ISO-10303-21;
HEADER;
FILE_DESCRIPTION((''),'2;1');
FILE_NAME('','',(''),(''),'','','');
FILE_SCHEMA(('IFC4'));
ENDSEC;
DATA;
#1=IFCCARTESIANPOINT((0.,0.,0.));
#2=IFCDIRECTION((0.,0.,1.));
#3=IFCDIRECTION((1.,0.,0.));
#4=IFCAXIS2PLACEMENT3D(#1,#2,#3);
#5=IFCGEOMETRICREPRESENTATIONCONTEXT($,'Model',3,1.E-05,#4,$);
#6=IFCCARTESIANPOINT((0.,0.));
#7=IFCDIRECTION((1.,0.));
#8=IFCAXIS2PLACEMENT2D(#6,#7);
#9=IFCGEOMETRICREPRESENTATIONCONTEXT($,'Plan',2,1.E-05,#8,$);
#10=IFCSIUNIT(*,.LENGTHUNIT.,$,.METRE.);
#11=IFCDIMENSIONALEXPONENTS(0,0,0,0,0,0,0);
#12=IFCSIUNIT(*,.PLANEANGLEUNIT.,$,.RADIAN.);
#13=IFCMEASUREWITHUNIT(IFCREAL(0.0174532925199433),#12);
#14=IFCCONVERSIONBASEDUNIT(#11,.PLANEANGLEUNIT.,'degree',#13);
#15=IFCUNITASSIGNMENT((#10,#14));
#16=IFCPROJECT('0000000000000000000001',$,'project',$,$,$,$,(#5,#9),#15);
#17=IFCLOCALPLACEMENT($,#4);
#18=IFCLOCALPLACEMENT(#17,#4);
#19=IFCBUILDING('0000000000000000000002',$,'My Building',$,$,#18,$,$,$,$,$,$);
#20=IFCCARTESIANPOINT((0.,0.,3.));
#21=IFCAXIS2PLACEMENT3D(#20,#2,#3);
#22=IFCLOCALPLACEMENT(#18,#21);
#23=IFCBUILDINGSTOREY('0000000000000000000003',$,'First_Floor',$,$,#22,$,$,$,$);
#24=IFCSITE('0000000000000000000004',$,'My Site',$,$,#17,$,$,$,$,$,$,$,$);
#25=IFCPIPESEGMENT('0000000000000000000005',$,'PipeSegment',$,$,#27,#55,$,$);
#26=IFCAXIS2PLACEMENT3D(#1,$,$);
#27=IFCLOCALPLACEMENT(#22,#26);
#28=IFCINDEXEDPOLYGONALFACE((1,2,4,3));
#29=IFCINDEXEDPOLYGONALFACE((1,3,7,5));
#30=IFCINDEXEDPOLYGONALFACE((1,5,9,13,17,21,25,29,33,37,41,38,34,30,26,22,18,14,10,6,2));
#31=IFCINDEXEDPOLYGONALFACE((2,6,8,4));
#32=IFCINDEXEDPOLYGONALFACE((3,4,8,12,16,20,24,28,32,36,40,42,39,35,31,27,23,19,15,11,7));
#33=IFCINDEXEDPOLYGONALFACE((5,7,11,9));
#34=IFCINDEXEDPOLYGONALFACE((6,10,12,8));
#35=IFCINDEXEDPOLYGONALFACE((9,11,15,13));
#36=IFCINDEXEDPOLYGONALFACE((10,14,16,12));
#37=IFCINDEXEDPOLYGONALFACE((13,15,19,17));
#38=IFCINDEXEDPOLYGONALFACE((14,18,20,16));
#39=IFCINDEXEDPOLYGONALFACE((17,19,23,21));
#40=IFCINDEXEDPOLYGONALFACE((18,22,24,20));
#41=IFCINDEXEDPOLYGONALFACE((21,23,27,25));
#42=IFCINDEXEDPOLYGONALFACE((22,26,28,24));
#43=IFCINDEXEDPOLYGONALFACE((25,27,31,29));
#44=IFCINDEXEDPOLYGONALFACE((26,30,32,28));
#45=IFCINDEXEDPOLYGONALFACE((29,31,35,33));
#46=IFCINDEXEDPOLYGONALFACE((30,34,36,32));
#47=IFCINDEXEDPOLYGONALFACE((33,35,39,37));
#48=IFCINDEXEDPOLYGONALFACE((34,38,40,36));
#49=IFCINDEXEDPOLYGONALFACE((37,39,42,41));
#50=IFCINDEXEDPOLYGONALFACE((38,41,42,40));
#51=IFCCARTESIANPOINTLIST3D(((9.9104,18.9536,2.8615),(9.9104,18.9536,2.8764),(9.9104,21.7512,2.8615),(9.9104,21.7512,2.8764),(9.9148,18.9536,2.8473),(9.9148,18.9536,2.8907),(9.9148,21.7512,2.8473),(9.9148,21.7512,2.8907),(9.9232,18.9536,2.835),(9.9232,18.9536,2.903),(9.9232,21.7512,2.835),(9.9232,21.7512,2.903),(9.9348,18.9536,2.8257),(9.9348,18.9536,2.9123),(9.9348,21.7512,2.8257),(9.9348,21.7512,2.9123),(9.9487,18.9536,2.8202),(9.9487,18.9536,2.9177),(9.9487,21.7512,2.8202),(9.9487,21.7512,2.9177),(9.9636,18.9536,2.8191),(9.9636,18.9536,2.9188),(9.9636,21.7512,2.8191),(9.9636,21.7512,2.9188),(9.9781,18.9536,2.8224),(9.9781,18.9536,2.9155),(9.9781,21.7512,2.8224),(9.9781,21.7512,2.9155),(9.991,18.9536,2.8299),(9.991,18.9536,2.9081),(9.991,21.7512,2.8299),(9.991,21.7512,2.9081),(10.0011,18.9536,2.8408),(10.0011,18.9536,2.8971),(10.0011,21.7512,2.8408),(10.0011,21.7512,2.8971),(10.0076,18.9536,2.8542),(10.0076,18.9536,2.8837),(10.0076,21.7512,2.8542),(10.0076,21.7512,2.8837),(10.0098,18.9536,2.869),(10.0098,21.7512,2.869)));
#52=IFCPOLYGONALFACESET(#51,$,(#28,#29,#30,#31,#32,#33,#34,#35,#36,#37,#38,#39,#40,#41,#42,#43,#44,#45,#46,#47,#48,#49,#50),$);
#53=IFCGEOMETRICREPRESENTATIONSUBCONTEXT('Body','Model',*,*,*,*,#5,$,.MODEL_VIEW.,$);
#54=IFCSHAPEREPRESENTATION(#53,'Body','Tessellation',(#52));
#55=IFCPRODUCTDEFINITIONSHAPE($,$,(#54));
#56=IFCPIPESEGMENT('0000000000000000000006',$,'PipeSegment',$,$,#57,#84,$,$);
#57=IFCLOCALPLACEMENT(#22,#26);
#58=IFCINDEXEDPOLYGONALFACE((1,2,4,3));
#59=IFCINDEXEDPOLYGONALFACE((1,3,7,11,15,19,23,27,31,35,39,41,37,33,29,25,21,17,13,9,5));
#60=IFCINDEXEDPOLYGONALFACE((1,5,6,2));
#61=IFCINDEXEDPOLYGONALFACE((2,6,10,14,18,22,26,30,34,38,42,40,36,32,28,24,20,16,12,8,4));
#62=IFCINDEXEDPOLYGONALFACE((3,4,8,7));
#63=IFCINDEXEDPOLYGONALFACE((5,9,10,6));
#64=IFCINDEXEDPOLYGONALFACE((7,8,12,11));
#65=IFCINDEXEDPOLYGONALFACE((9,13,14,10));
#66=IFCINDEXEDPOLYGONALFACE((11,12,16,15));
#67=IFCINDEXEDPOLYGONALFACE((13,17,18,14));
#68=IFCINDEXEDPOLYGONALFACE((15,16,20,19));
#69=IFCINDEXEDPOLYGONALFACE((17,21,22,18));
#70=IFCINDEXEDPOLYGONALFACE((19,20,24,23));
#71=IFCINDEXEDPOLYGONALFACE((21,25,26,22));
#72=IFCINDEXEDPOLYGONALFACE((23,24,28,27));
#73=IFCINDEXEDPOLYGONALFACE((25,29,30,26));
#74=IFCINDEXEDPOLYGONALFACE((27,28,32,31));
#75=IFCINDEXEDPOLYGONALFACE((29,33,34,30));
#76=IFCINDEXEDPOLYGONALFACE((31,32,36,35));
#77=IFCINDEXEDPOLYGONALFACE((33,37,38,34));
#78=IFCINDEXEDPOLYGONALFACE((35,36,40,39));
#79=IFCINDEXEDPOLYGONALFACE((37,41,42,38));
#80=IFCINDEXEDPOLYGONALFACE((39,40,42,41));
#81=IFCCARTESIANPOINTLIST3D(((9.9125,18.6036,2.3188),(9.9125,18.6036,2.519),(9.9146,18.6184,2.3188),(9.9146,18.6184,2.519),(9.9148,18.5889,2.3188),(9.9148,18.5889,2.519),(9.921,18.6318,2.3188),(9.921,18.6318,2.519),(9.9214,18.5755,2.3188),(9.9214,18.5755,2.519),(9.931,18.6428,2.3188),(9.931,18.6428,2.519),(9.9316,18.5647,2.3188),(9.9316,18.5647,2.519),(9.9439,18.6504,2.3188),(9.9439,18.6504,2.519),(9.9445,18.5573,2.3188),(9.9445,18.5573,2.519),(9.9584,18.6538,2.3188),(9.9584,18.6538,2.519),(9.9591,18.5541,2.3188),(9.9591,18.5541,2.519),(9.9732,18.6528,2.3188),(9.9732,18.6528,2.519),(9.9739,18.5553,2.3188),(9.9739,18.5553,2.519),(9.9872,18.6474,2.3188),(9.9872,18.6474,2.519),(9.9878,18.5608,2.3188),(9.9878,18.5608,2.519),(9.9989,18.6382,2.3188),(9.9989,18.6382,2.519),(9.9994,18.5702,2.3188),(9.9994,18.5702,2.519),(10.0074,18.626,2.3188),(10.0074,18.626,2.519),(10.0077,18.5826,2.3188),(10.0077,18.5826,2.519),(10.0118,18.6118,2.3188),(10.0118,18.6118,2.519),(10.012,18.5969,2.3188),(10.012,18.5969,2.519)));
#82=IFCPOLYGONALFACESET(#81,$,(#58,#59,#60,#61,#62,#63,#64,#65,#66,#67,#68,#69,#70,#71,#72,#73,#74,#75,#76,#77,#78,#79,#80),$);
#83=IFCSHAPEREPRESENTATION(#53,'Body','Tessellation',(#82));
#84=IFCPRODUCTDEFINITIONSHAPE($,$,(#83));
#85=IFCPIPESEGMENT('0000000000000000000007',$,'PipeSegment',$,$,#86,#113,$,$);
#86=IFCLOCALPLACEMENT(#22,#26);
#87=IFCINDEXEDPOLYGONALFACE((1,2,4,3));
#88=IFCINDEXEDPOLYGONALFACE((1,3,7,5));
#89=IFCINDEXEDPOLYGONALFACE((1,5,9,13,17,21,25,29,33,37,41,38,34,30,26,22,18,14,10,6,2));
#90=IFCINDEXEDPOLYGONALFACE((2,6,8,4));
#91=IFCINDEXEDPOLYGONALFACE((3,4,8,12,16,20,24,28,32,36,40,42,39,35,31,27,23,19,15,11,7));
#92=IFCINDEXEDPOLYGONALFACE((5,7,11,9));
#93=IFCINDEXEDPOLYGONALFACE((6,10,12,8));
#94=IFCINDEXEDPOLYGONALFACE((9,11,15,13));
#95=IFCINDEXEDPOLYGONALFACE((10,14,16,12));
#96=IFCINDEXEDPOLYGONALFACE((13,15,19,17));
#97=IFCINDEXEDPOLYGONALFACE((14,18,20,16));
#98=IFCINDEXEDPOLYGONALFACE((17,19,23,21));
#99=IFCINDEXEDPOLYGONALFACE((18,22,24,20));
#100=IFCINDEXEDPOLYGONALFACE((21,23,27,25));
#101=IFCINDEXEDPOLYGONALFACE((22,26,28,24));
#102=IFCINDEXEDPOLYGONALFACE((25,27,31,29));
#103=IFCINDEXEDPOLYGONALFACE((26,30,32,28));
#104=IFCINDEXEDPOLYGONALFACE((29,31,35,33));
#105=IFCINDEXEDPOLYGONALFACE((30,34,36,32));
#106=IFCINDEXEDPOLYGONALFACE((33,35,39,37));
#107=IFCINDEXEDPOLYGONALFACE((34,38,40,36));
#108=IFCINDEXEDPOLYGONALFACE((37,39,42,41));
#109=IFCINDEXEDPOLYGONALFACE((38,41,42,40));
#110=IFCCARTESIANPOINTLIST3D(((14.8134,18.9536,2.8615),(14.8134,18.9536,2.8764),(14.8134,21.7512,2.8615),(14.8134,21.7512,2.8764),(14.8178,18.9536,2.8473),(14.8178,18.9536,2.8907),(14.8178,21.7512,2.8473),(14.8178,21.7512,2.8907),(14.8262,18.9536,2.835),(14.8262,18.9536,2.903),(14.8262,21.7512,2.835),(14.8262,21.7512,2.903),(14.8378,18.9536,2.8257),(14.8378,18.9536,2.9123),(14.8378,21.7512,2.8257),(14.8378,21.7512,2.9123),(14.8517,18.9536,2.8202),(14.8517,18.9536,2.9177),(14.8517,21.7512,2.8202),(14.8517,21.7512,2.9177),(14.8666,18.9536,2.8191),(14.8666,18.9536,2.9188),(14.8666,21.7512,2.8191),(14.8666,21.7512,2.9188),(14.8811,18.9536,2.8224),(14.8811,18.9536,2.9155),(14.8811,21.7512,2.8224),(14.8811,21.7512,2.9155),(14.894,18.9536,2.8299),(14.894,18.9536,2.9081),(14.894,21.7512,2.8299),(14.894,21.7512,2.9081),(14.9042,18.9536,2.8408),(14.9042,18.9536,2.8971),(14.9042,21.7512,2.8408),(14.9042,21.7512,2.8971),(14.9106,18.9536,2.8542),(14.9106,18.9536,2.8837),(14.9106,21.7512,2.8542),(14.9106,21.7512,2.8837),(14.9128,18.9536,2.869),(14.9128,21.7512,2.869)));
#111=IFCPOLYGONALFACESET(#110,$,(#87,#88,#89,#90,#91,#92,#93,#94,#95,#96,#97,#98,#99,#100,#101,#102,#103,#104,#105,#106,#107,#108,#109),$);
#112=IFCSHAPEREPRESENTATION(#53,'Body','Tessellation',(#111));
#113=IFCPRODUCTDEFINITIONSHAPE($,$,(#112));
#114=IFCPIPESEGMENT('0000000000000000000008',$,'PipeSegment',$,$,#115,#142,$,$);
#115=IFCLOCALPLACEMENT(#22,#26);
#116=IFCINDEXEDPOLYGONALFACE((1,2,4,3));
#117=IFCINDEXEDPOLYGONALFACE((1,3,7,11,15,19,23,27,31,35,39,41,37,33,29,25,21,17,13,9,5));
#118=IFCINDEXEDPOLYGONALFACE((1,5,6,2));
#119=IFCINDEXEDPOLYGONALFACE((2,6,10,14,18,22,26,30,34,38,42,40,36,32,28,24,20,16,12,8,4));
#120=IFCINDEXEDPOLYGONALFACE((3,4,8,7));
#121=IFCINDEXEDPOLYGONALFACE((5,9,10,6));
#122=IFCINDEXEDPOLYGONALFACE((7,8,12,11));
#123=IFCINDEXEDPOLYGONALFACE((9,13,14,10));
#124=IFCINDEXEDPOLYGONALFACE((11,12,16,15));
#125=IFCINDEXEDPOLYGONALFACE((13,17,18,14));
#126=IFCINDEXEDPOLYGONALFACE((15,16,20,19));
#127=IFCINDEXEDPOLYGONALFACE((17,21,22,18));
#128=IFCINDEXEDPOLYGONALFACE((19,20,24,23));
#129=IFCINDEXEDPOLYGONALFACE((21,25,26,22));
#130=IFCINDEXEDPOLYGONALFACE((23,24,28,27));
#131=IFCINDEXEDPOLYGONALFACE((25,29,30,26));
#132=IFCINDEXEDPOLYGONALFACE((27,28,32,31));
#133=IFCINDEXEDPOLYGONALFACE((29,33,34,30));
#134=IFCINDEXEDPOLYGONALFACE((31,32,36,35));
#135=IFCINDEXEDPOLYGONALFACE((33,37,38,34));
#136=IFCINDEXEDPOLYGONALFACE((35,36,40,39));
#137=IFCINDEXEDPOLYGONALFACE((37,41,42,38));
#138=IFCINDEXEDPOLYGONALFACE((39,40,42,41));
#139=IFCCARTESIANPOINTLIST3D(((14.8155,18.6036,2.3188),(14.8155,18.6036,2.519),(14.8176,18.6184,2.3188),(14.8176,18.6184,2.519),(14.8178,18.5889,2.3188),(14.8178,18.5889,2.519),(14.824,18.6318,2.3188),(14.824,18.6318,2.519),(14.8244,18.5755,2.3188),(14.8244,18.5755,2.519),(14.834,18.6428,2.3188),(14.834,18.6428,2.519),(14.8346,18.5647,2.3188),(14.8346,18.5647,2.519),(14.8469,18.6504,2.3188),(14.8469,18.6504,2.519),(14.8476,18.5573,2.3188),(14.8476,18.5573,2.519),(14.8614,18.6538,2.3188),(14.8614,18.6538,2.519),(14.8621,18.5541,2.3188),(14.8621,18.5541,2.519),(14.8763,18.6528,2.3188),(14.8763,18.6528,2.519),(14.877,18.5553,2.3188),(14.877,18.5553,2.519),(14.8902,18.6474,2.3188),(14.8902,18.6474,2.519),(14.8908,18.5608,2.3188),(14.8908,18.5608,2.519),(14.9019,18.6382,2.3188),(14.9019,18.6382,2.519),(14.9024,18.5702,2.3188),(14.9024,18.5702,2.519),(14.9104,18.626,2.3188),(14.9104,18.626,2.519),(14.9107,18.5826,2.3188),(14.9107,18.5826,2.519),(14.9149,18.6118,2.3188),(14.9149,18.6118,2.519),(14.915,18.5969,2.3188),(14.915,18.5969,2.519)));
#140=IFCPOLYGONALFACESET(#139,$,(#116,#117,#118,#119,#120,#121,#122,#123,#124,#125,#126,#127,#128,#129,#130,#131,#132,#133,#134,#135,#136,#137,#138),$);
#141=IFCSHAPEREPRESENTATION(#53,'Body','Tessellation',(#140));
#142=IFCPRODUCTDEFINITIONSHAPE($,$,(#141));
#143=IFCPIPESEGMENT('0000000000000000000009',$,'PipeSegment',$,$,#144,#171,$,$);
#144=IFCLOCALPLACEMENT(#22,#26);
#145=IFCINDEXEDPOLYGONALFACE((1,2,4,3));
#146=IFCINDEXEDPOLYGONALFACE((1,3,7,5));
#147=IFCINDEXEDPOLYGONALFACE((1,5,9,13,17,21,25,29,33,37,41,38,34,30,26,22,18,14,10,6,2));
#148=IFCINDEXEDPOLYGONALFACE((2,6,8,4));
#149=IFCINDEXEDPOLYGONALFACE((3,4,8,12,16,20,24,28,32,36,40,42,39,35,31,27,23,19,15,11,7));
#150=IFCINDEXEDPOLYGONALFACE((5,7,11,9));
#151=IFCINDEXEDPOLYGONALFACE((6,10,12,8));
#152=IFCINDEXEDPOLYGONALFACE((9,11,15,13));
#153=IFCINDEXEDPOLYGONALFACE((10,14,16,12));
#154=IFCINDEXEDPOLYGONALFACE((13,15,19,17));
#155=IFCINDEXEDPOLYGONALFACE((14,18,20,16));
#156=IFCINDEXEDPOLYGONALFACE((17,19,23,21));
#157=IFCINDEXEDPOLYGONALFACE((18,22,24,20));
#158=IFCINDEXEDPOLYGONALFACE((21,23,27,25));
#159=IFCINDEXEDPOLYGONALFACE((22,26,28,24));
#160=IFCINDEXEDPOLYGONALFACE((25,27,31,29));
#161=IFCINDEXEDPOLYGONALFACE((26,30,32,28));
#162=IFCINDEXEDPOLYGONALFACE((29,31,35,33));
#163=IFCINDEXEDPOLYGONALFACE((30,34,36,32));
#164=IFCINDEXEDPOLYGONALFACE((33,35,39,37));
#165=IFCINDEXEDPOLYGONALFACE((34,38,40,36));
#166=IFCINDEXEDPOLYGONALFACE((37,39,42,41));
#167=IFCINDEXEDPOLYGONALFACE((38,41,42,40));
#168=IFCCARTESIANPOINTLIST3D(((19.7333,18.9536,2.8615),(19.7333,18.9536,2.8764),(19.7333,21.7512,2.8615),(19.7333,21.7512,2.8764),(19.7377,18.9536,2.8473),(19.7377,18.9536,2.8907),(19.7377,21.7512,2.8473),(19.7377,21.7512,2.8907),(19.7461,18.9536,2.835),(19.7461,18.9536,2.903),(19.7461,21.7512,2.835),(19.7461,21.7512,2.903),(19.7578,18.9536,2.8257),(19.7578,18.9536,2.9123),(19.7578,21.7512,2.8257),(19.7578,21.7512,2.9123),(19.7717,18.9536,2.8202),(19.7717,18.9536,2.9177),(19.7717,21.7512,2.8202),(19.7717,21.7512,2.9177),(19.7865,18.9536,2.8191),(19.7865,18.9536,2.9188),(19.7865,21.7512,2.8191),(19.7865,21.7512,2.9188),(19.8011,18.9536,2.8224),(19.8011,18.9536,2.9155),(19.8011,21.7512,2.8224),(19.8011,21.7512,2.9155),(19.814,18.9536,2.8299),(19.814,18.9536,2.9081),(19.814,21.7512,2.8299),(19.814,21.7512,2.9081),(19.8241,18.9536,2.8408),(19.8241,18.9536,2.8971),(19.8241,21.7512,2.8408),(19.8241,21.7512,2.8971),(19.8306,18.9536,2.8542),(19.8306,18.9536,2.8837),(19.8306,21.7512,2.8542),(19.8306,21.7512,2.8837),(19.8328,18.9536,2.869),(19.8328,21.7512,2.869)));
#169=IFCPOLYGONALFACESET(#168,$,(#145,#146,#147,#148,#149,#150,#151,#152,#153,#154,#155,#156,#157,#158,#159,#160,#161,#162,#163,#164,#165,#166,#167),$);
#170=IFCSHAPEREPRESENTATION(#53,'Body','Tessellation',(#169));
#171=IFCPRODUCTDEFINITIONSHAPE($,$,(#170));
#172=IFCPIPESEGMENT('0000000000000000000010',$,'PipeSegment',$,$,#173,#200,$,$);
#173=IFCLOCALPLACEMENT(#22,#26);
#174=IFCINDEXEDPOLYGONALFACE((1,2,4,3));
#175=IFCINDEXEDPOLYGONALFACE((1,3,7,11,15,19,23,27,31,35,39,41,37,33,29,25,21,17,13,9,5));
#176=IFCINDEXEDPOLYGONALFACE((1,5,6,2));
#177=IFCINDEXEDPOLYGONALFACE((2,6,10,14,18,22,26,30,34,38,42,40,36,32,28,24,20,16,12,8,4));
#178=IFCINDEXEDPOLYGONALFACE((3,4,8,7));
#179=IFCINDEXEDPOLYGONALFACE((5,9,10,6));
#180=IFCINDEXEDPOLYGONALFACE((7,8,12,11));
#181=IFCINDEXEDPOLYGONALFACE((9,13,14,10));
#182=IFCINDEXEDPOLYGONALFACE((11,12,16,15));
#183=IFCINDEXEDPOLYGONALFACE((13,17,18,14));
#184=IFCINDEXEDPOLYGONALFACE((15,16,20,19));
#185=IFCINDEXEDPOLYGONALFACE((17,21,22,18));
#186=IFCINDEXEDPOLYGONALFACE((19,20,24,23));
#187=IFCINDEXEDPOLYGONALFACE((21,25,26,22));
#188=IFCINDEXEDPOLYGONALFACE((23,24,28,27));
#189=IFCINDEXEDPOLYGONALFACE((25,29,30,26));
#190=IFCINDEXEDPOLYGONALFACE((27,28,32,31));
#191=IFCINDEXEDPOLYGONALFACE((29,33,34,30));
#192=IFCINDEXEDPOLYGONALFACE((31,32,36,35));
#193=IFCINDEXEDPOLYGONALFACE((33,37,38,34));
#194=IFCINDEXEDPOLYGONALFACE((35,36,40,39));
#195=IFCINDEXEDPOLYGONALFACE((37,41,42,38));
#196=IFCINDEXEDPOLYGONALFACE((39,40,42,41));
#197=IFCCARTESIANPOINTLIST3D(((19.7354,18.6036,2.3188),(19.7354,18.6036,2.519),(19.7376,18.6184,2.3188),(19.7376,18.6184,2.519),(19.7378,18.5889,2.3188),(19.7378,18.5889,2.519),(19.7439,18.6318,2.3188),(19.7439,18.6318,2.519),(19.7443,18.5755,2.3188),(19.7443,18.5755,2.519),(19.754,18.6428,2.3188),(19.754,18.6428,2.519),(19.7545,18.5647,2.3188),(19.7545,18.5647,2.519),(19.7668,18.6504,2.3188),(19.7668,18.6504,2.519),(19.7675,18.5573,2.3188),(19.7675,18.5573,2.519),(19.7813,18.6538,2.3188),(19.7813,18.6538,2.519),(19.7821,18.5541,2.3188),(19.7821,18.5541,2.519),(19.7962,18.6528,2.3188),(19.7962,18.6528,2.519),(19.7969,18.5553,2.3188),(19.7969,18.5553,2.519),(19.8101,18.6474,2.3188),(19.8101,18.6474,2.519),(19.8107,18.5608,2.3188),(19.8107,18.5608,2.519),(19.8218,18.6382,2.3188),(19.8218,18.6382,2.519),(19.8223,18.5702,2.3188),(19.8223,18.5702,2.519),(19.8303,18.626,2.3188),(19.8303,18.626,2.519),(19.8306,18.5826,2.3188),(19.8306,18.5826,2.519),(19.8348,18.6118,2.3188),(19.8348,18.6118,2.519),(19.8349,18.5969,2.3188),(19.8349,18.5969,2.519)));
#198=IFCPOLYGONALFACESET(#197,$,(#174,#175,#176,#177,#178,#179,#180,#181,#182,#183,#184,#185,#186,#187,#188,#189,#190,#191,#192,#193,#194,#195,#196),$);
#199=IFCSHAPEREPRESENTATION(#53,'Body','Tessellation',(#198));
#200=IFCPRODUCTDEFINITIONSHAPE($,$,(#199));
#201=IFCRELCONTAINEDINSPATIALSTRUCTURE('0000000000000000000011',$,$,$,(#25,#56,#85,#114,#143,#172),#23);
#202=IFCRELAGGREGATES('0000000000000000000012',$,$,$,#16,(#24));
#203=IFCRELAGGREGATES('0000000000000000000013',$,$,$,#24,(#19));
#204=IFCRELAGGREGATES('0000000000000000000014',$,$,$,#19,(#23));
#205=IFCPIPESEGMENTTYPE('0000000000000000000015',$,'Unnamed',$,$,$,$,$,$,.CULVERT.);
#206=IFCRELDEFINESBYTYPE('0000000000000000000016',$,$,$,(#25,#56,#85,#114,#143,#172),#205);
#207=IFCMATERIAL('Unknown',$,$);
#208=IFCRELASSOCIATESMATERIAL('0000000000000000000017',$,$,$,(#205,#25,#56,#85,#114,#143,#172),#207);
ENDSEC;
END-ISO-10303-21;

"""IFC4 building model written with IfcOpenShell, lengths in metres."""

from ifc_helpers import new_model, entity, si_unit, converted_unit, frame, origin_with_axes, origin_2d_with_axis, place, context, subcontext, project, spatial, circle, extrude, material, material_profile, profile_set, profile_usage, type_object, element, save


model = new_model("IFC4")

# Units and contexts
model_context = context("Model", 3, precision=1e-05, world=origin_with_axes())
plan_context = context("Plan", 2, precision=1e-05, world=origin_2d_with_axis())
body_context_1 = subcontext(model_context, "Body", "Model", "MODEL_VIEW")
ifc_project = project(units=[si_unit("LENGTHUNIT", "METRE"), converted_unit("PLANEANGLEUNIT", "degree", entity("IfcReal", 0.0174532925199433), si_unit("PLANEANGLEUNIT", "RADIAN"), dimensions=[0, 0, 0, 0, 0, 0, 0])], contexts=[model_context, plan_context])

# Site, building, storey
site_placement = place(None, origin_with_axes())
site = spatial("IfcSite", under=ifc_project, at=site_placement, Name="My Site")
building_placement = place(site_placement, origin_with_axes())
building = spatial("IfcBuilding", under=site, at=building_placement, Name="My Building")
storey_placement = place(building_placement, frame((0.0, 0.0, 3.0), z_axis=(0.0, 0.0, 1.0), x_axis=(1.0, 0.0, 0.0)))
storey = spatial("IfcBuildingStorey", under=building, at=storey_placement, Name="First_Floor")

# Shared definitions
ifc_material = material(Name="Unknown")

# Pipe segments
ifc_material_profile_1 = material_profile(ifc_material, circle(Radius=0.05))
ifc_profile_set_1 = profile_set([ifc_material_profile_1])
ifc_profile_usage_1 = profile_usage(ifc_profile_set_1, cardinal=5)
pipe_segment_type = type_object("IfcPipeSegmentType", Name="Unnamed", PredefinedType="CULVERT", material=ifc_profile_set_1)
pipe_segment_1_placement = place(storey_placement, frame((9.9598, 21.7512, 2.869), z_axis=(0.0, -1.0, 0.0), x_axis=(1.0, 0.0, 0.0)))
element("IfcPipeSegment", 1, at=pipe_segment_1_placement, inside=storey, type_object=pipe_segment_type, material=ifc_profile_usage_1, Name="PipeSegment", context=body_context_1, shape_type="SweptSolid", body=[
    extrude(circle(Radius=0.05), origin_with_axes(), (0.0, 0.0, 1.0), 2.7976),
])
ifc_profile_usage_2 = profile_usage(ifc_profile_set_1, cardinal=5)
pipe_segment_2_placement = place(storey_placement, frame((9.9625, 18.604, 2.519), z_axis=(-0.000001, 0.0, -1.0), x_axis=(-0.999975, -0.007084, 0.000001)))
element("IfcPipeSegment", 2, at=pipe_segment_2_placement, inside=storey, type_object=pipe_segment_type, material=ifc_profile_usage_2, Name="PipeSegment", context=body_context_1, shape_type="SweptSolid", body=[
    extrude(circle(Radius=0.05), origin_with_axes(), (0.0, 0.0, 1.0), 0.2002),
])
ifc_profile_usage_3 = profile_usage(ifc_profile_set_1, cardinal=5)
pipe_segment_3_placement = place(storey_placement, frame((14.8628, 21.7512, 2.869), z_axis=(0.0, -1.0, 0.0), x_axis=(1.0, 0.0, 0.0)))
element("IfcPipeSegment", 3, at=pipe_segment_3_placement, inside=storey, type_object=pipe_segment_type, material=ifc_profile_usage_3, Name="PipeSegment", context=body_context_1, shape_type="SweptSolid", body=[
    extrude(circle(Radius=0.05), origin_with_axes(), (0.0, 0.0, 1.0), 2.7976),
])
ifc_profile_usage_4 = profile_usage(ifc_profile_set_1, cardinal=5)
pipe_segment_4_placement = place(storey_placement, frame((14.8655, 18.604, 2.519), z_axis=(-0.000001, 0.0, -1.0), x_axis=(-0.999975, -0.007084, 0.000001)))
element("IfcPipeSegment", 4, at=pipe_segment_4_placement, inside=storey, type_object=pipe_segment_type, material=ifc_profile_usage_4, Name="PipeSegment", context=body_context_1, shape_type="SweptSolid", body=[
    extrude(circle(Radius=0.05), origin_with_axes(), (0.0, 0.0, 1.0), 0.2002),
])
ifc_profile_usage_5 = profile_usage(ifc_profile_set_1, cardinal=5)
pipe_segment_5_placement = place(storey_placement, frame((19.7828, 21.7512, 2.869), z_axis=(0.0, -1.0, 0.0), x_axis=(1.0, 0.0, 0.0)))
element("IfcPipeSegment", 5, at=pipe_segment_5_placement, inside=storey, type_object=pipe_segment_type, material=ifc_profile_usage_5, Name="PipeSegment", context=body_context_1, shape_type="SweptSolid", body=[
    extrude(circle(Radius=0.05), origin_with_axes(), (0.0, 0.0, 1.0), 2.7976),
])
ifc_profile_usage_6 = profile_usage(ifc_profile_set_1, cardinal=5)
pipe_segment_6_placement = place(storey_placement, frame((19.7854, 18.604, 2.519), z_axis=(-0.000001, 0.0, -1.0), x_axis=(-0.999975, -0.007084, 0.000001)))
element("IfcPipeSegment", 6, at=pipe_segment_6_placement, inside=storey, type_object=pipe_segment_type, material=ifc_profile_usage_6, Name="PipeSegment", context=body_context_1, shape_type="SweptSolid", body=[
    extrude(circle(Radius=0.05), origin_with_axes(), (0.0, 0.0, 1.0), 0.2002),
])

save(model, "model.ifc")
